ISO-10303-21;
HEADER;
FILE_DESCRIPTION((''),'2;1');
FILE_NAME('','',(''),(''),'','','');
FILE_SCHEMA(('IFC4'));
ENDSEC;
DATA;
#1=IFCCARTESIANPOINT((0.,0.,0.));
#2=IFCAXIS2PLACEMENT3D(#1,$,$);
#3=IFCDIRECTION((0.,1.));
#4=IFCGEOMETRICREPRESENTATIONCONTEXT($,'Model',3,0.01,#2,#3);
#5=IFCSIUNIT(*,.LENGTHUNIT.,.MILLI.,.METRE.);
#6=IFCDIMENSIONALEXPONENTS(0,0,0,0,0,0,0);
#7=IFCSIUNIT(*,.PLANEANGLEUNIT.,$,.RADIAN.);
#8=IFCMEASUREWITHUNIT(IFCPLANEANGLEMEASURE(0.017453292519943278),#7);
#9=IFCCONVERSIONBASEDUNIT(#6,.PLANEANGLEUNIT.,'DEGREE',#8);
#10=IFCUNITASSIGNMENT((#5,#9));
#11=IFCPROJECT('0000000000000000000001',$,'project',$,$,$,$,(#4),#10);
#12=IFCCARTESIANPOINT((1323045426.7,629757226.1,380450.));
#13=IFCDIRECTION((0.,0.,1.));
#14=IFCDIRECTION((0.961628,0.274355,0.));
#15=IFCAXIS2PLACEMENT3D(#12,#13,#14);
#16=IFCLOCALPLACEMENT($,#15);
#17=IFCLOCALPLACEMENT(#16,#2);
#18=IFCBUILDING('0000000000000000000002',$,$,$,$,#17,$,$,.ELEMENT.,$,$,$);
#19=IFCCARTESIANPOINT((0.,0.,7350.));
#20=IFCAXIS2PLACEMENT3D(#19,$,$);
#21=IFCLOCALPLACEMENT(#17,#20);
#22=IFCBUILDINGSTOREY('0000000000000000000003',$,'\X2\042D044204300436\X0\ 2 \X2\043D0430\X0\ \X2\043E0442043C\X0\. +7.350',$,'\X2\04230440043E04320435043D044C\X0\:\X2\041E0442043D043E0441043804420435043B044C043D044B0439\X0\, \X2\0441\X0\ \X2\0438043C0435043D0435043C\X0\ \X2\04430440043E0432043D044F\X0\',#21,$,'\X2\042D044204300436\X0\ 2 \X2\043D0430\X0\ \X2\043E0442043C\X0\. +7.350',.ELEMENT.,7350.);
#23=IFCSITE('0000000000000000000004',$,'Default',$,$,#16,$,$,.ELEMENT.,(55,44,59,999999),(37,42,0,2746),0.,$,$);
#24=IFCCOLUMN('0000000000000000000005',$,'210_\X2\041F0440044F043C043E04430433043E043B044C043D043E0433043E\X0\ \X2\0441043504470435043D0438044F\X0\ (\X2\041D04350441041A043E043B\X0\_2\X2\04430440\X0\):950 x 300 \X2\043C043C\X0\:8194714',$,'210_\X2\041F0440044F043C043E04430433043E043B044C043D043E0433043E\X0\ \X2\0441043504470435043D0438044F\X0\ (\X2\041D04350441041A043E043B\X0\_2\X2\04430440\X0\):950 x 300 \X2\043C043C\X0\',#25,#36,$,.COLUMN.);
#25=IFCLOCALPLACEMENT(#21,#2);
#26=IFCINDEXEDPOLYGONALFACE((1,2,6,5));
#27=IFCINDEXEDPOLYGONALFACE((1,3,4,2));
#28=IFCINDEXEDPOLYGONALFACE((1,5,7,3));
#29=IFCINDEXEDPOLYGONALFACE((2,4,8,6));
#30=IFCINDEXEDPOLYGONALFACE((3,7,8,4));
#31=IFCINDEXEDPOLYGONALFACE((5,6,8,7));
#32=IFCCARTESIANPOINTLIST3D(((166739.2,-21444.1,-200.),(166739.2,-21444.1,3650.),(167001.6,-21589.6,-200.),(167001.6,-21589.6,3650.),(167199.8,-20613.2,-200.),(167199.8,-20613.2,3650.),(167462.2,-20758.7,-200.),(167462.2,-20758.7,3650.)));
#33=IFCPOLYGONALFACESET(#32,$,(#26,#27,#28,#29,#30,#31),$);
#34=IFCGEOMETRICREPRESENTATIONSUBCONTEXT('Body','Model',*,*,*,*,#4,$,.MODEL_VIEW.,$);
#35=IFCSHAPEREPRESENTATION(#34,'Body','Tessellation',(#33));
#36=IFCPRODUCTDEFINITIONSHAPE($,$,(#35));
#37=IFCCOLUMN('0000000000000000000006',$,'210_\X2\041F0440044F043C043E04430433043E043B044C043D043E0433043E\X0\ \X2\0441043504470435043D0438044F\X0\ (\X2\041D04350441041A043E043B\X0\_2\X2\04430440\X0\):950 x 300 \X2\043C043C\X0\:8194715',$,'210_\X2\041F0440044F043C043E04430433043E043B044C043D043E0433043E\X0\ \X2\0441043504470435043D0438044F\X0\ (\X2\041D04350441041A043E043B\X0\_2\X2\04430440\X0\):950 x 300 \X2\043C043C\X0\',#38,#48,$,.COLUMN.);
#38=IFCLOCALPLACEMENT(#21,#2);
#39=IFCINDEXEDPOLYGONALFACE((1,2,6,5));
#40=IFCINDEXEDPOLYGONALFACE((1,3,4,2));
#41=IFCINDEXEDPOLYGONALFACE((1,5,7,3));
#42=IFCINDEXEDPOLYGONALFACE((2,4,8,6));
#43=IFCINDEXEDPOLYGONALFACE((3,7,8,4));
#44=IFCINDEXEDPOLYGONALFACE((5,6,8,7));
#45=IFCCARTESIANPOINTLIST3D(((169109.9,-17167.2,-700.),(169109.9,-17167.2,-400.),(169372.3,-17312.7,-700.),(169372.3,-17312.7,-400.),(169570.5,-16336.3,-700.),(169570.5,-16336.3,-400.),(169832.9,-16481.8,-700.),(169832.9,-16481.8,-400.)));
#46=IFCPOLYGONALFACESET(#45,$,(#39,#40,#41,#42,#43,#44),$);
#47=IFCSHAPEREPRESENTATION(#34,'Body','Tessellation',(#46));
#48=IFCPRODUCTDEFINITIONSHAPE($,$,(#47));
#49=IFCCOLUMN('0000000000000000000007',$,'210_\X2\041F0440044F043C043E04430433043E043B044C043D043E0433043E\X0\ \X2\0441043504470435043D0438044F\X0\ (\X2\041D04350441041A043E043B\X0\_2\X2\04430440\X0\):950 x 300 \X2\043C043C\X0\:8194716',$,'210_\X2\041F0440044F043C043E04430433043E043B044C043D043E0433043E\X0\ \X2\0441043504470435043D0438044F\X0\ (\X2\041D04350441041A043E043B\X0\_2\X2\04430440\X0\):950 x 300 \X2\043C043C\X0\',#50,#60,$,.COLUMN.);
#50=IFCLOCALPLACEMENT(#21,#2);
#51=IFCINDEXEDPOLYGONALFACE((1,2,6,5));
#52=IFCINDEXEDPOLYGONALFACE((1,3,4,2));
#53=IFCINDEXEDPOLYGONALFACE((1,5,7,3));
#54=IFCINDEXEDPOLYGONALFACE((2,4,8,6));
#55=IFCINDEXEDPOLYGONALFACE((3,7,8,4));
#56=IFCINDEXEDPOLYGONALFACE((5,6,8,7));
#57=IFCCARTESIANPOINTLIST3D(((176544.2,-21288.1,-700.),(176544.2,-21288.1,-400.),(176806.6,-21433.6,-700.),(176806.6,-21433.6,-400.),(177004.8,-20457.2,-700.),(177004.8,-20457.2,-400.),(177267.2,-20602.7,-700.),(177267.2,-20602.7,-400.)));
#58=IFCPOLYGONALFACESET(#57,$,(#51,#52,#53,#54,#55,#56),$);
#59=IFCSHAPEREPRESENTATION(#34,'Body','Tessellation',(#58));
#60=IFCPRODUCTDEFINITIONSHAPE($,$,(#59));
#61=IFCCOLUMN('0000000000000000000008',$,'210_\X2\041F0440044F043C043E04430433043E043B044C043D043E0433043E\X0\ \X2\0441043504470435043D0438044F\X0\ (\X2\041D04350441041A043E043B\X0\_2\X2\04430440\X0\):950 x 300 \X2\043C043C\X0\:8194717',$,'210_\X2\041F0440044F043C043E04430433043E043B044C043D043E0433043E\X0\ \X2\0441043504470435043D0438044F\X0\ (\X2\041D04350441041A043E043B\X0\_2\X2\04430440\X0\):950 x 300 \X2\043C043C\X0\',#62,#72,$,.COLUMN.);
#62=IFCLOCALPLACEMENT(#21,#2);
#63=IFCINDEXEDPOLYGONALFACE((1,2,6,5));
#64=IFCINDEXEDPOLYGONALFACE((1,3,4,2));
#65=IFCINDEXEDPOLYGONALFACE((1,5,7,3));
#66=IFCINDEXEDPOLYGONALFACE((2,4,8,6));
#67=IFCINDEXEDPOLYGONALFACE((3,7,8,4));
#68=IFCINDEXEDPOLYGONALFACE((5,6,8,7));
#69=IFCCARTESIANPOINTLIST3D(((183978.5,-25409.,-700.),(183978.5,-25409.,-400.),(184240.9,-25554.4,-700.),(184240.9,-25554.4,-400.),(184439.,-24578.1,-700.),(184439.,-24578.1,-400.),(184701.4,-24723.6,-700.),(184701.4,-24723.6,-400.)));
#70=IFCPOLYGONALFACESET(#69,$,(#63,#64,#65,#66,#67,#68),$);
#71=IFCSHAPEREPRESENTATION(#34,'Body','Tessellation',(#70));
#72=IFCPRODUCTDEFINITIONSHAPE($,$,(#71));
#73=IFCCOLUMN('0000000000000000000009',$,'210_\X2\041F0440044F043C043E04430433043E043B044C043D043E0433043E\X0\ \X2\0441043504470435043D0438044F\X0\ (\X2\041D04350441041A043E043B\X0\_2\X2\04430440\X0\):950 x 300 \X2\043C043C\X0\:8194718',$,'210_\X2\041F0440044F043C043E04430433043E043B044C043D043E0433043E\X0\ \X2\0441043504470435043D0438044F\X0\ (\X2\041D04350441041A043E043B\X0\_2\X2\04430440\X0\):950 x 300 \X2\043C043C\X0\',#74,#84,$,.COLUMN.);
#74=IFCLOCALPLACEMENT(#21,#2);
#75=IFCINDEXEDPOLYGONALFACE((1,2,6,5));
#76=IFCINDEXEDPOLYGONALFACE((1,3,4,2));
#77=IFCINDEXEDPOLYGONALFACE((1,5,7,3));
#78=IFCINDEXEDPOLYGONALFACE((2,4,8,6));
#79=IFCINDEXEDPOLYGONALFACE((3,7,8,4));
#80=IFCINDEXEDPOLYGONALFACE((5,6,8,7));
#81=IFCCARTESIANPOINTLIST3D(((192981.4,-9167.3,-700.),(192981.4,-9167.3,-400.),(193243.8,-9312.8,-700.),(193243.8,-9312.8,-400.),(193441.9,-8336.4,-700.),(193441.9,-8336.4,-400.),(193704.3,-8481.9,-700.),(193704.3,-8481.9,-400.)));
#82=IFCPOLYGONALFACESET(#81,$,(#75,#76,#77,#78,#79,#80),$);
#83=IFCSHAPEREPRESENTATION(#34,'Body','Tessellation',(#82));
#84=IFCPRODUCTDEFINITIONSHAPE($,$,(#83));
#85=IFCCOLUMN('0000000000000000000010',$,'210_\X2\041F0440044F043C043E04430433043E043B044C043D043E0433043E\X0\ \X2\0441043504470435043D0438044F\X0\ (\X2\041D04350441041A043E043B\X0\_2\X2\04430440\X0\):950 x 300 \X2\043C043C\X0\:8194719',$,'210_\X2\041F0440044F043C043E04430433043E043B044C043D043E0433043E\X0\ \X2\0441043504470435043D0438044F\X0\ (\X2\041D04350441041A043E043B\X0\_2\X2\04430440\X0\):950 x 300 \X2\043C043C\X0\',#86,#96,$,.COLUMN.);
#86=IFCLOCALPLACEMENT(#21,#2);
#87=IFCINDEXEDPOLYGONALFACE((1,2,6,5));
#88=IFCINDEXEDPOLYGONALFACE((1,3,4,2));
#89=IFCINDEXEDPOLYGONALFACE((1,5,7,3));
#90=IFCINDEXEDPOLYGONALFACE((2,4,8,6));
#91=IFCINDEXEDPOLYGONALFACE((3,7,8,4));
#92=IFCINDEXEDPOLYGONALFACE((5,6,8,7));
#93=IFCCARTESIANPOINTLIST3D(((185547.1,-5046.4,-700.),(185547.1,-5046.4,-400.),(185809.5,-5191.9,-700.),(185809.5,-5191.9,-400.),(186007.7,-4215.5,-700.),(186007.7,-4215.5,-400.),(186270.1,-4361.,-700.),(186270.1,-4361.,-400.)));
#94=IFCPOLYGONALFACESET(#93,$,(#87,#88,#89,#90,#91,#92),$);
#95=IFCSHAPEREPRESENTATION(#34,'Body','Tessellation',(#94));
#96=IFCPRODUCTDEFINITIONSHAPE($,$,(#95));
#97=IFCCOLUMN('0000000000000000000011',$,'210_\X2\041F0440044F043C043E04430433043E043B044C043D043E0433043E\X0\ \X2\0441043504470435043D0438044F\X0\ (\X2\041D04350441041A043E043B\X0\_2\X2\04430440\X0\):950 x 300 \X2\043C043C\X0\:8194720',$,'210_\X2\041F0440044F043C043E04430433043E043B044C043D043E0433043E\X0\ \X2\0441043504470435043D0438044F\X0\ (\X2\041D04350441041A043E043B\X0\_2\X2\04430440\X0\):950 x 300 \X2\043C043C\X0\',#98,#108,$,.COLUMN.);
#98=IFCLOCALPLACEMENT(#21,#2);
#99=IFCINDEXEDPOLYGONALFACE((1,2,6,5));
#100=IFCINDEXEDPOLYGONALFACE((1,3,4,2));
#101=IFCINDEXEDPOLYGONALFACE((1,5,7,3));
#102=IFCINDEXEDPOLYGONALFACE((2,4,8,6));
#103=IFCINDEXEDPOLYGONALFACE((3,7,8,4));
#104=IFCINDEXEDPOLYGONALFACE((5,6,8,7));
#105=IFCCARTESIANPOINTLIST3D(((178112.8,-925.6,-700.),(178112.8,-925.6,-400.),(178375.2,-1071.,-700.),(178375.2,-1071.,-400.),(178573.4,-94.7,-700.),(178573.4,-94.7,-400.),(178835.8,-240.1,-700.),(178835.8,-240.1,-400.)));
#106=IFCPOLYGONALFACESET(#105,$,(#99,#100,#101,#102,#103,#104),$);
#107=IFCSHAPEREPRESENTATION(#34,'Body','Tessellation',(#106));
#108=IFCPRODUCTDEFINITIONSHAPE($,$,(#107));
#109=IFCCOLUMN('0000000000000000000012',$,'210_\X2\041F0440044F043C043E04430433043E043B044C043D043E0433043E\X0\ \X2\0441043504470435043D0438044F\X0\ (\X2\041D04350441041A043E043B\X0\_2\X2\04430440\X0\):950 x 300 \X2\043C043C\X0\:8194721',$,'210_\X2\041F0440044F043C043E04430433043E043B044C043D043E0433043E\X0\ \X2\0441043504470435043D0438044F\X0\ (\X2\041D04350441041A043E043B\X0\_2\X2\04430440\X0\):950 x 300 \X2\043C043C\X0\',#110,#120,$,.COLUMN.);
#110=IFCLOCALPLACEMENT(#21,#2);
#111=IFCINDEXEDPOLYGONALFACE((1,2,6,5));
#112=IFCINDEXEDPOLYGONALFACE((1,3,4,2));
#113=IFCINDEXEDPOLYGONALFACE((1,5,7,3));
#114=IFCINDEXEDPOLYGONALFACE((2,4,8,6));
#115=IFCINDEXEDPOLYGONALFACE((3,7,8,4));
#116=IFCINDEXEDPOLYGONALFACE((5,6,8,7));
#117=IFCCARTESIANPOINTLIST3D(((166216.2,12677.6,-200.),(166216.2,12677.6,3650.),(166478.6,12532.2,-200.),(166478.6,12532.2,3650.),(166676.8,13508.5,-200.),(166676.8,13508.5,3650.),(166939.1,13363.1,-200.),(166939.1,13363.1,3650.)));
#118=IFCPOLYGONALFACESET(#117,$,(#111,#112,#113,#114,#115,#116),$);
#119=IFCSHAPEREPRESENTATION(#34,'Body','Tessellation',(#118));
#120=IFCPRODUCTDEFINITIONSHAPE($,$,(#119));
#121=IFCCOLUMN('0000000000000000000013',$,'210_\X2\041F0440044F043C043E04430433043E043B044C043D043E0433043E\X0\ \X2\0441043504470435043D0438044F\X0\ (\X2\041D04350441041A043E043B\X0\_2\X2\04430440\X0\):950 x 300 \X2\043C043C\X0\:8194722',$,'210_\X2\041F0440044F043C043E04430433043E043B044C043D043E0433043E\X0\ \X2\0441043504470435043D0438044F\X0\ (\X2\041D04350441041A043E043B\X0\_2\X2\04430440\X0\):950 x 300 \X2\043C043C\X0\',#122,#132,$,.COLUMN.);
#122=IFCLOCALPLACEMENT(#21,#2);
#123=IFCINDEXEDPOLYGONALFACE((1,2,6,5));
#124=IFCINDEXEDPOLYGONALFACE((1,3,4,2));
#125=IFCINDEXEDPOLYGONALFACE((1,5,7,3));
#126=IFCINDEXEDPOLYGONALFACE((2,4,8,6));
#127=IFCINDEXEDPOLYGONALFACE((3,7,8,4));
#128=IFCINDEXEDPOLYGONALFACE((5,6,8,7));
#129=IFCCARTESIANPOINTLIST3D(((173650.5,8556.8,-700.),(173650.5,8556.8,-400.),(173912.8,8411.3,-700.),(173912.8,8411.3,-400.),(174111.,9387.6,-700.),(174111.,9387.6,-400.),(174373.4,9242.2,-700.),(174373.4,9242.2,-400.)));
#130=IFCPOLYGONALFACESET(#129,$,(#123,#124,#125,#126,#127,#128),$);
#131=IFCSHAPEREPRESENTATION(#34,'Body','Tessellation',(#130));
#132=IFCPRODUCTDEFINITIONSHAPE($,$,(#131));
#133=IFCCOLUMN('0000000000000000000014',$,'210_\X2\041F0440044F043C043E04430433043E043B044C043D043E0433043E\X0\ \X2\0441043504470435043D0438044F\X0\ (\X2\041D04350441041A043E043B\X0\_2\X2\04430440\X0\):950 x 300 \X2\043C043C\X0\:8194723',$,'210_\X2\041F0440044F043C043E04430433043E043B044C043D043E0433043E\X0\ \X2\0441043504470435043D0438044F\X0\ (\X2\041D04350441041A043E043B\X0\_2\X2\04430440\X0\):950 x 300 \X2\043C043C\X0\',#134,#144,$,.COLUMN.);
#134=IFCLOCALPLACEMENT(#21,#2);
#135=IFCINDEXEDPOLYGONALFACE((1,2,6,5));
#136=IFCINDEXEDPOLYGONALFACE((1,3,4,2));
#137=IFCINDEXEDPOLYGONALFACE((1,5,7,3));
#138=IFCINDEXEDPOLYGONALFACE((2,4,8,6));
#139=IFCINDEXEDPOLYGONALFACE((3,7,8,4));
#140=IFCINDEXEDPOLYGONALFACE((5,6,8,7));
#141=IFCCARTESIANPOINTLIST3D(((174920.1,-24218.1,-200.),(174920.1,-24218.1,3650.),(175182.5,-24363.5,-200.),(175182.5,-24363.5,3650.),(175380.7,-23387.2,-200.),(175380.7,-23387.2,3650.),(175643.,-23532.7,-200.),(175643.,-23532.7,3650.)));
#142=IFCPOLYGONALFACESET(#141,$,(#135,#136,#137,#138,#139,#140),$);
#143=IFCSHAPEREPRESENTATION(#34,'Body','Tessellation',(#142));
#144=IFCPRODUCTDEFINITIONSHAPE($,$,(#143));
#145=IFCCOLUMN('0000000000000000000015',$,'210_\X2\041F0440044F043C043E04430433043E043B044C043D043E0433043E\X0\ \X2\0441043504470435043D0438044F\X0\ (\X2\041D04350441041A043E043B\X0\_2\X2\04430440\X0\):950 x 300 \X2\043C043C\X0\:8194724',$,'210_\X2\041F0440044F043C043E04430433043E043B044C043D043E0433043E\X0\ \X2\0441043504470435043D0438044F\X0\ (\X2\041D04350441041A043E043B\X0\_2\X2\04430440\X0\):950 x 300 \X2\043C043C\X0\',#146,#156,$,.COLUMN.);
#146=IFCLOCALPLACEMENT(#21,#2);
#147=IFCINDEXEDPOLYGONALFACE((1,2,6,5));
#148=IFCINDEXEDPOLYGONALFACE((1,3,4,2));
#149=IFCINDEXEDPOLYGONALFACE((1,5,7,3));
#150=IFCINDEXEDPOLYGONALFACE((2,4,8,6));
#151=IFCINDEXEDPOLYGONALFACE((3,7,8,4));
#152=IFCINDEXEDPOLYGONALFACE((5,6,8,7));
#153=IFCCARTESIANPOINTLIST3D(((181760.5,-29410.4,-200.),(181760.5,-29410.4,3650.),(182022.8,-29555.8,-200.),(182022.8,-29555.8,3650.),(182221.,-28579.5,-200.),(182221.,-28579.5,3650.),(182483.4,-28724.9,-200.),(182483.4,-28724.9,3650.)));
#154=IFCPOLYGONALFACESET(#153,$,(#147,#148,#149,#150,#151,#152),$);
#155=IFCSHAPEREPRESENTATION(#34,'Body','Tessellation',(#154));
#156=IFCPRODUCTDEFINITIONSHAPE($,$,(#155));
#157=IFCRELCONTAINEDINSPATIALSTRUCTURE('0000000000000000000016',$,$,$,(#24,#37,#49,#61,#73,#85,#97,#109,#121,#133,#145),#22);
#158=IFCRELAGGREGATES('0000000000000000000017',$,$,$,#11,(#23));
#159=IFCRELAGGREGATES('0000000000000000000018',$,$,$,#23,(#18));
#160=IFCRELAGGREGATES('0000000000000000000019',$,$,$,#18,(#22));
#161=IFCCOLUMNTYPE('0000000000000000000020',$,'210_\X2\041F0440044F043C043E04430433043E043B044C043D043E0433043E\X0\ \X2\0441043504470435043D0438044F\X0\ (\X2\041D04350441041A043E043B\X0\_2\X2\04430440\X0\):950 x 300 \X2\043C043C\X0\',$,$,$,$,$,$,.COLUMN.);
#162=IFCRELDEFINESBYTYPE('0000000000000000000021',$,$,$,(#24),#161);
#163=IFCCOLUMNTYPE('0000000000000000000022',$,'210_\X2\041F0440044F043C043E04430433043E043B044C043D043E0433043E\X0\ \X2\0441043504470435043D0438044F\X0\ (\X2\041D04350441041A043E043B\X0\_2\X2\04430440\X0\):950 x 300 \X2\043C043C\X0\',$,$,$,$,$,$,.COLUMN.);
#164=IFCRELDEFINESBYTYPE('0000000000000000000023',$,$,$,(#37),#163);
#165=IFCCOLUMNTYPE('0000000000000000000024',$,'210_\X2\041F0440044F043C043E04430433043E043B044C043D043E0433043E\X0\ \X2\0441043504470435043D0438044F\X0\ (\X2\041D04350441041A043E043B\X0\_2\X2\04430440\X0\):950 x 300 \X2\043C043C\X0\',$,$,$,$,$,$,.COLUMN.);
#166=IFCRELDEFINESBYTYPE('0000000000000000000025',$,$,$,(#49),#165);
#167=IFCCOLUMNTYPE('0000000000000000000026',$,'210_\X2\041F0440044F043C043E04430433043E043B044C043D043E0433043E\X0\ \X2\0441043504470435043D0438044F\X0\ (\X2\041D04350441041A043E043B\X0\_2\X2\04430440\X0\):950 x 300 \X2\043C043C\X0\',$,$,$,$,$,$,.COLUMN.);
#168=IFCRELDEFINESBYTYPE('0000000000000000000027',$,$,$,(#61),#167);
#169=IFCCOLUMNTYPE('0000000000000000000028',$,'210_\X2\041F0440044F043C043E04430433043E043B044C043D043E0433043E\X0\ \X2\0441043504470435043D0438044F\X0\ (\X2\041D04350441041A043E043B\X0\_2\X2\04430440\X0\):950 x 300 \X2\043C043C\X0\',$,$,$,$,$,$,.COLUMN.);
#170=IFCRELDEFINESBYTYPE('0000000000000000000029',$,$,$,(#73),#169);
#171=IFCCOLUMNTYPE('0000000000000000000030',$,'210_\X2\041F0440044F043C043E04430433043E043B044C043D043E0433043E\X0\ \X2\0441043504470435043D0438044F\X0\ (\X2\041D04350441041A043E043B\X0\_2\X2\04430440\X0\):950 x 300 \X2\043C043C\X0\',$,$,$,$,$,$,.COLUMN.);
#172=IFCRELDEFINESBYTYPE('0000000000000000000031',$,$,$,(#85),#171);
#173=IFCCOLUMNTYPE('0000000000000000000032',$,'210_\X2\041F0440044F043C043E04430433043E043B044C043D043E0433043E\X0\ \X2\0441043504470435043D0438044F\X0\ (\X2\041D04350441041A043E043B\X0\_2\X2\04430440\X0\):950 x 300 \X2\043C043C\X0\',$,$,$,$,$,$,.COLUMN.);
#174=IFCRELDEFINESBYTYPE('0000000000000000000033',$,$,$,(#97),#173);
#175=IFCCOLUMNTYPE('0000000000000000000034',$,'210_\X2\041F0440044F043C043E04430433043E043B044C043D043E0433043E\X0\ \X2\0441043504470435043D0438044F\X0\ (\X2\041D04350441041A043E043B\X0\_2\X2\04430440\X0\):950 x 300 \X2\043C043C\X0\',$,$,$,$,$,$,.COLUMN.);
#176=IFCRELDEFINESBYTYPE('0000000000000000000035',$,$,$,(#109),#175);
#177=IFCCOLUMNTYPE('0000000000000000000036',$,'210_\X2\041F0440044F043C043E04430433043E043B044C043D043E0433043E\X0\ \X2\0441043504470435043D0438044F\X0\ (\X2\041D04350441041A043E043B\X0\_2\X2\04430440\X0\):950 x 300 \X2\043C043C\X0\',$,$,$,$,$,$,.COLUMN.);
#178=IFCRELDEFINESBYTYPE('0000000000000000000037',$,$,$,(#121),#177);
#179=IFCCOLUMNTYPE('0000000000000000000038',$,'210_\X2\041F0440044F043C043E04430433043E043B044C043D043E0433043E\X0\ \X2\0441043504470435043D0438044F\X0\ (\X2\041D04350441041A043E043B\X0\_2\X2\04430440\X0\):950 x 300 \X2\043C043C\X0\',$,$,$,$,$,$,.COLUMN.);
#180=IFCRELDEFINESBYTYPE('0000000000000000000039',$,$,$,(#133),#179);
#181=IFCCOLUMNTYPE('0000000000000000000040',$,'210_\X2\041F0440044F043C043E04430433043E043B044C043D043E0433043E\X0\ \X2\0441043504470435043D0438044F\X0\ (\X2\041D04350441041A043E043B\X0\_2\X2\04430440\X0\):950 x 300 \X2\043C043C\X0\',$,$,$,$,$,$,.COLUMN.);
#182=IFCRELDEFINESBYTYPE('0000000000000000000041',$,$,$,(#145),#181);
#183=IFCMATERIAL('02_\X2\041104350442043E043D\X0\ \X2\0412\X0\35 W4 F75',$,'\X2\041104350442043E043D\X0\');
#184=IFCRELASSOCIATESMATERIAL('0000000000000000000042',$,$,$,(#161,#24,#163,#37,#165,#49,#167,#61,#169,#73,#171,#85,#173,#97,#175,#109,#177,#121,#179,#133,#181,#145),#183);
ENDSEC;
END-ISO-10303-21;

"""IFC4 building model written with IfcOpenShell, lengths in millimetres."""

from ifc_helpers import new_model, entity, si_unit, converted_unit, direction, frame, origin, place, context, subcontext, project, spatial, indexed_curve, outline, extrude, source, transform, mapped, material, type_object, type_shapes, element, save


model = new_model("IFC4")

# Units and contexts
model_context = context("Model", 3, precision=0.01, world=origin(), true_north=direction((0.0, 1.0)))
body_context = subcontext(model_context, "Body", "Model", "MODEL_VIEW")
ifc_project = project(units=[si_unit("LENGTHUNIT", "METRE", prefix="MILLI"), converted_unit("PLANEANGLEUNIT", "DEGREE", entity("IfcPlaneAngleMeasure", 0.017453292519943278), si_unit("PLANEANGLEUNIT", "RADIAN"), dimensions=[0, 0, 0, 0, 0, 0, 0])], contexts=[model_context])

# Site, building, storey
site_placement = place(None, frame((1323045426.7, 629757226.1, 380450.0), z_axis=(0.0, 0.0, 1.0), x_axis=(0.961628, 0.274355, 0.0)))
site = spatial("IfcSite", under=ifc_project, at=site_placement, Name="Default", CompositionType="ELEMENT", RefLatitude=(55, 44, 59, 999999), RefLongitude=(37, 42, 0, 2746), RefElevation=0.0)
building_placement = place(site_placement, origin())
building = spatial("IfcBuilding", under=site, at=building_placement, CompositionType="ELEMENT")
storey_placement = place(building_placement, frame((0.0, 0.0, 7350.0)))
storey = spatial("IfcBuildingStorey", under=building, at=storey_placement, Name="Этаж 2 на отм. +7.350", ObjectType="Уровень:Относительный, с именем уровня", LongName="Этаж 2 на отм. +7.350", CompositionType="ELEMENT", Elevation=7350.0)

# Columns
ifc_material_1 = material(Name="02_Бетон В35 W4 F75", Category="Бетон")
column_type_1 = type_object("IfcColumnType", Name="210_Прямоугольного сечения (НесКол_2ур):950 x 300 мм", PredefinedType="COLUMN", material=ifc_material_1)
shared_shape_1 = source(origin(), body_context, "Body", "SweptSolid", [
    extrude(outline(indexed_curve([(-150.0, -475.0), (150.0, -475.0), (150.0, 475.0), (-150.0, 475.0), (-150.0, -475.0)], self_intersect=False)), frame((167100.7, -21101.4, 7150.0), z_axis=(0.0, 0.0, 1.0), x_axis=(-0.87462, 0.48481, 0.0)), (0.0, 0.0, 1.0), 3850.0),
])
type_shapes(column_type_1, [shared_shape_1])
column_1_placement = place(storey_placement, frame((0.0, 0.0, -7350.0)))
element("IfcColumn", 1, at=column_1_placement, inside=storey, type_object=column_type_1, material=ifc_material_1, Name="210_Прямоугольного сечения (НесКол_2ур):950 x 300 мм:8194714", ObjectType="210_Прямоугольного сечения (НесКол_2ур):950 x 300 мм", PredefinedType="COLUMN", context=body_context, shape_type="MappedRepresentation", body=[
    mapped(shared_shape_1, transform((0.0, 0.0, 0.0), scale=1.0)),
])
column_type_2 = type_object("IfcColumnType", Name="210_Прямоугольного сечения (НесКол_2ур):950 x 300 мм", PredefinedType="COLUMN", material=ifc_material_1)
shared_shape_2 = source(origin(), body_context, "Body", "SweptSolid", [
    extrude(outline(indexed_curve([(-150.0, -150.0), (150.0, -150.0), (150.0, 150.0), (-150.0, 150.0), (-150.0, -150.0)], self_intersect=False)), frame((169241.1, -17240.0, 6800.0), z_axis=(0.48481, 0.87462, 0.0), x_axis=(0.0, 0.0, 1.0)), (0.0, 0.0, 1.0), 950.0),
])
type_shapes(column_type_2, [shared_shape_2])
column_2_placement = place(storey_placement, frame((0.0, 0.0, -7350.0)))
element("IfcColumn", 2, at=column_2_placement, inside=storey, type_object=column_type_2, material=ifc_material_1, Name="210_Прямоугольного сечения (НесКол_2ур):950 x 300 мм:8194715", ObjectType="210_Прямоугольного сечения (НесКол_2ур):950 x 300 мм", PredefinedType="COLUMN", context=body_context, shape_type="MappedRepresentation", body=[
    mapped(shared_shape_2, transform((0.0, 0.0, 0.0), scale=1.0)),
])
column_type_3 = type_object("IfcColumnType", Name="210_Прямоугольного сечения (НесКол_2ур):950 x 300 мм", PredefinedType="COLUMN", material=ifc_material_1)
shared_shape_3 = source(origin(), body_context, "Body", "SweptSolid", [
    extrude(outline(indexed_curve([(-150.0, -150.0), (150.0, -150.0), (150.0, 150.0), (-150.0, 150.0), (-150.0, -150.0)], self_intersect=False)), frame((176675.4, -21360.8, 6800.0), z_axis=(0.48481, 0.87462, 0.0), x_axis=(0.0, 0.0, 1.0)), (0.0, 0.0, 1.0), 950.0),
])
type_shapes(column_type_3, [shared_shape_3])
column_3_placement = place(storey_placement, frame((0.0, 0.0, -7350.0)))
element("IfcColumn", 3, at=column_3_placement, inside=storey, type_object=column_type_3, material=ifc_material_1, Name="210_Прямоугольного сечения (НесКол_2ур):950 x 300 мм:8194716", ObjectType="210_Прямоугольного сечения (НесКол_2ур):950 x 300 мм", PredefinedType="COLUMN", context=body_context, shape_type="MappedRepresentation", body=[
    mapped(shared_shape_3, transform((0.0, 0.0, 0.0), scale=1.0)),
])
column_type_4 = type_object("IfcColumnType", Name="210_Прямоугольного сечения (НесКол_2ур):950 x 300 мм", PredefinedType="COLUMN", material=ifc_material_1)
shared_shape_4 = source(origin(), body_context, "Body", "SweptSolid", [
    extrude(outline(indexed_curve([(-150.0, -150.0), (150.0, -150.0), (150.0, 150.0), (-150.0, 150.0), (-150.0, -150.0)], self_intersect=False)), frame((184109.7, -25481.7, 6800.0), z_axis=(0.48481, 0.87462, 0.0), x_axis=(0.0, 0.0, 1.0)), (0.0, 0.0, 1.0), 950.0),
])
type_shapes(column_type_4, [shared_shape_4])
column_4_placement = place(storey_placement, frame((0.0, 0.0, -7350.0)))
element("IfcColumn", 4, at=column_4_placement, inside=storey, type_object=column_type_4, material=ifc_material_1, Name="210_Прямоугольного сечения (НесКол_2ур):950 x 300 мм:8194717", ObjectType="210_Прямоугольного сечения (НесКол_2ур):950 x 300 мм", PredefinedType="COLUMN", context=body_context, shape_type="MappedRepresentation", body=[
    mapped(shared_shape_4, transform((0.0, 0.0, 0.0), scale=1.0)),
])
column_type_5 = type_object("IfcColumnType", Name="210_Прямоугольного сечения (НесКол_2ур):950 x 300 мм", PredefinedType="COLUMN", material=ifc_material_1)
shared_shape_5 = source(origin(), body_context, "Body", "SweptSolid", [
    extrude(outline(indexed_curve([(-150.0, -150.0), (150.0, -150.0), (150.0, 150.0), (-150.0, 150.0), (-150.0, -150.0)], self_intersect=False)), frame((193112.6, -9240.0, 6800.0), z_axis=(0.48481, 0.87462, 0.0), x_axis=(0.0, 0.0, 1.0)), (0.0, 0.0, 1.0), 950.0),
])
type_shapes(column_type_5, [shared_shape_5])
column_5_placement = place(storey_placement, frame((0.0, 0.0, -7350.0)))
element("IfcColumn", 5, at=column_5_placement, inside=storey, type_object=column_type_5, material=ifc_material_1, Name="210_Прямоугольного сечения (НесКол_2ур):950 x 300 мм:8194718", ObjectType="210_Прямоугольного сечения (НесКол_2ур):950 x 300 мм", PredefinedType="COLUMN", context=body_context, shape_type="MappedRepresentation", body=[
    mapped(shared_shape_5, transform((0.0, 0.0, 0.0), scale=1.0)),
])
column_type_6 = type_object("IfcColumnType", Name="210_Прямоугольного сечения (НесКол_2ур):950 x 300 мм", PredefinedType="COLUMN", material=ifc_material_1)
shared_shape_6 = source(origin(), body_context, "Body", "SweptSolid", [
    extrude(outline(indexed_curve([(-150.0, -150.0), (150.0, -150.0), (150.0, 150.0), (-150.0, 150.0), (-150.0, -150.0)], self_intersect=False)), frame((185678.3, -5119.2, 6800.0), z_axis=(0.48481, 0.87462, 0.0), x_axis=(0.0, 0.0, 1.0)), (0.0, 0.0, 1.0), 950.0),
])
type_shapes(column_type_6, [shared_shape_6])
column_6_placement = place(storey_placement, frame((0.0, 0.0, -7350.0)))
element("IfcColumn", 6, at=column_6_placement, inside=storey, type_object=column_type_6, material=ifc_material_1, Name="210_Прямоугольного сечения (НесКол_2ур):950 x 300 мм:8194719", ObjectType="210_Прямоугольного сечения (НесКол_2ур):950 x 300 мм", PredefinedType="COLUMN", context=body_context, shape_type="MappedRepresentation", body=[
    mapped(shared_shape_6, transform((0.0, 0.0, 0.0), scale=1.0)),
])
column_type_7 = type_object("IfcColumnType", Name="210_Прямоугольного сечения (НесКол_2ур):950 x 300 мм", PredefinedType="COLUMN", material=ifc_material_1)
shared_shape_7 = source(origin(), body_context, "Body", "SweptSolid", [
    extrude(outline(indexed_curve([(-150.0, -150.0), (150.0, -150.0), (150.0, 150.0), (-150.0, 150.0), (-150.0, -150.0)], self_intersect=False)), frame((178244.0, -998.3, 6800.0), z_axis=(0.48481, 0.87462, 0.0), x_axis=(0.0, 0.0, 1.0)), (0.0, 0.0, 1.0), 950.0),
])
type_shapes(column_type_7, [shared_shape_7])
column_7_placement = place(storey_placement, frame((0.0, 0.0, -7350.0)))
element("IfcColumn", 7, at=column_7_placement, inside=storey, type_object=column_type_7, material=ifc_material_1, Name="210_Прямоугольного сечения (НесКол_2ур):950 x 300 мм:8194720", ObjectType="210_Прямоугольного сечения (НесКол_2ур):950 x 300 мм", PredefinedType="COLUMN", context=body_context, shape_type="MappedRepresentation", body=[
    mapped(shared_shape_7, transform((0.0, 0.0, 0.0), scale=1.0)),
])
column_type_8 = type_object("IfcColumnType", Name="210_Прямоугольного сечения (НесКол_2ур):950 x 300 мм", PredefinedType="COLUMN", material=ifc_material_1)
shared_shape_8 = source(origin(), body_context, "Body", "SweptSolid", [
    extrude(outline(indexed_curve([(-150.0, -475.0), (150.0, -475.0), (150.0, 475.0), (-150.0, 475.0), (-150.0, -475.0)], self_intersect=False)), frame((166577.7, 13020.4, 7150.0), z_axis=(0.0, 0.0, 1.0), x_axis=(-0.87462, 0.48481, 0.0)), (0.0, 0.0, 1.0), 3850.0),
])
type_shapes(column_type_8, [shared_shape_8])
column_8_placement = place(storey_placement, frame((0.0, 0.0, -7350.0)))
element("IfcColumn", 8, at=column_8_placement, inside=storey, type_object=column_type_8, material=ifc_material_1, Name="210_Прямоугольного сечения (НесКол_2ур):950 x 300 мм:8194721", ObjectType="210_Прямоугольного сечения (НесКол_2ур):950 x 300 мм", PredefinedType="COLUMN", context=body_context, shape_type="MappedRepresentation", body=[
    mapped(shared_shape_8, transform((0.0, 0.0, 0.0), scale=1.0)),
])
column_type_9 = type_object("IfcColumnType", Name="210_Прямоугольного сечения (НесКол_2ур):950 x 300 мм", PredefinedType="COLUMN", material=ifc_material_1)
shared_shape_9 = source(origin(), body_context, "Body", "SweptSolid", [
    extrude(outline(indexed_curve([(-150.0, -150.0), (150.0, -150.0), (150.0, 150.0), (-150.0, 150.0), (-150.0, -150.0)], self_intersect=False)), frame((173781.7, 8484.0, 6800.0), z_axis=(0.48481, 0.87462, 0.0), x_axis=(0.0, 0.0, 1.0)), (0.0, 0.0, 1.0), 950.0),
])
type_shapes(column_type_9, [shared_shape_9])
column_9_placement = place(storey_placement, frame((0.0, 0.0, -7350.0)))
element("IfcColumn", 9, at=column_9_placement, inside=storey, type_object=column_type_9, material=ifc_material_1, Name="210_Прямоугольного сечения (НесКол_2ур):950 x 300 мм:8194722", ObjectType="210_Прямоугольного сечения (НесКол_2ур):950 x 300 мм", PredefinedType="COLUMN", context=body_context, shape_type="MappedRepresentation", body=[
    mapped(shared_shape_9, transform((0.0, 0.0, 0.0), scale=1.0)),
])
column_type_10 = type_object("IfcColumnType", Name="210_Прямоугольного сечения (НесКол_2ур):950 x 300 мм", PredefinedType="COLUMN", material=ifc_material_1)
shared_shape_10 = source(origin(), body_context, "Body", "SweptSolid", [
    extrude(outline(indexed_curve([(-150.0, -475.0), (150.0, -475.0), (150.0, 475.0), (-150.0, 475.0), (-150.0, -475.0)], self_intersect=False)), frame((175281.6, -23875.4, 7150.0), z_axis=(0.0, 0.0, 1.0), x_axis=(-0.87462, 0.48481, 0.0)), (0.0, 0.0, 1.0), 3850.0),
])
type_shapes(column_type_10, [shared_shape_10])
column_10_placement = place(storey_placement, frame((0.0, 0.0, -7350.0)))
element("IfcColumn", 10, at=column_10_placement, inside=storey, type_object=column_type_10, material=ifc_material_1, Name="210_Прямоугольного сечения (НесКол_2ур):950 x 300 мм:8194723", ObjectType="210_Прямоугольного сечения (НесКол_2ур):950 x 300 мм", PredefinedType="COLUMN", context=body_context, shape_type="MappedRepresentation", body=[
    mapped(shared_shape_10, transform((0.0, 0.0, 0.0), scale=1.0)),
])
column_type_11 = type_object("IfcColumnType", Name="210_Прямоугольного сечения (НесКол_2ур):950 x 300 мм", PredefinedType="COLUMN", material=ifc_material_1)
shared_shape_11 = source(origin(), body_context, "Body", "SweptSolid", [
    extrude(outline(indexed_curve([(-150.0, -475.0), (150.0, -475.0), (150.0, 475.0), (-150.0, 475.0), (-150.0, -475.0)], self_intersect=False)), frame((182121.9, -29067.7, 7150.0), z_axis=(0.0, 0.0, 1.0), x_axis=(-0.87462, 0.48481, 0.0)), (0.0, 0.0, 1.0), 3850.0),
])
type_shapes(column_type_11, [shared_shape_11])
column_11_placement = place(storey_placement, frame((0.0, 0.0, -7350.0)))
element("IfcColumn", 11, at=column_11_placement, inside=storey, type_object=column_type_11, material=ifc_material_1, Name="210_Прямоугольного сечения (НесКол_2ур):950 x 300 мм:8194724", ObjectType="210_Прямоугольного сечения (НесКол_2ур):950 x 300 мм", PredefinedType="COLUMN", context=body_context, shape_type="MappedRepresentation", body=[
    mapped(shared_shape_11, transform((0.0, 0.0, 0.0), scale=1.0)),
])

save(model, "model.ifc")
